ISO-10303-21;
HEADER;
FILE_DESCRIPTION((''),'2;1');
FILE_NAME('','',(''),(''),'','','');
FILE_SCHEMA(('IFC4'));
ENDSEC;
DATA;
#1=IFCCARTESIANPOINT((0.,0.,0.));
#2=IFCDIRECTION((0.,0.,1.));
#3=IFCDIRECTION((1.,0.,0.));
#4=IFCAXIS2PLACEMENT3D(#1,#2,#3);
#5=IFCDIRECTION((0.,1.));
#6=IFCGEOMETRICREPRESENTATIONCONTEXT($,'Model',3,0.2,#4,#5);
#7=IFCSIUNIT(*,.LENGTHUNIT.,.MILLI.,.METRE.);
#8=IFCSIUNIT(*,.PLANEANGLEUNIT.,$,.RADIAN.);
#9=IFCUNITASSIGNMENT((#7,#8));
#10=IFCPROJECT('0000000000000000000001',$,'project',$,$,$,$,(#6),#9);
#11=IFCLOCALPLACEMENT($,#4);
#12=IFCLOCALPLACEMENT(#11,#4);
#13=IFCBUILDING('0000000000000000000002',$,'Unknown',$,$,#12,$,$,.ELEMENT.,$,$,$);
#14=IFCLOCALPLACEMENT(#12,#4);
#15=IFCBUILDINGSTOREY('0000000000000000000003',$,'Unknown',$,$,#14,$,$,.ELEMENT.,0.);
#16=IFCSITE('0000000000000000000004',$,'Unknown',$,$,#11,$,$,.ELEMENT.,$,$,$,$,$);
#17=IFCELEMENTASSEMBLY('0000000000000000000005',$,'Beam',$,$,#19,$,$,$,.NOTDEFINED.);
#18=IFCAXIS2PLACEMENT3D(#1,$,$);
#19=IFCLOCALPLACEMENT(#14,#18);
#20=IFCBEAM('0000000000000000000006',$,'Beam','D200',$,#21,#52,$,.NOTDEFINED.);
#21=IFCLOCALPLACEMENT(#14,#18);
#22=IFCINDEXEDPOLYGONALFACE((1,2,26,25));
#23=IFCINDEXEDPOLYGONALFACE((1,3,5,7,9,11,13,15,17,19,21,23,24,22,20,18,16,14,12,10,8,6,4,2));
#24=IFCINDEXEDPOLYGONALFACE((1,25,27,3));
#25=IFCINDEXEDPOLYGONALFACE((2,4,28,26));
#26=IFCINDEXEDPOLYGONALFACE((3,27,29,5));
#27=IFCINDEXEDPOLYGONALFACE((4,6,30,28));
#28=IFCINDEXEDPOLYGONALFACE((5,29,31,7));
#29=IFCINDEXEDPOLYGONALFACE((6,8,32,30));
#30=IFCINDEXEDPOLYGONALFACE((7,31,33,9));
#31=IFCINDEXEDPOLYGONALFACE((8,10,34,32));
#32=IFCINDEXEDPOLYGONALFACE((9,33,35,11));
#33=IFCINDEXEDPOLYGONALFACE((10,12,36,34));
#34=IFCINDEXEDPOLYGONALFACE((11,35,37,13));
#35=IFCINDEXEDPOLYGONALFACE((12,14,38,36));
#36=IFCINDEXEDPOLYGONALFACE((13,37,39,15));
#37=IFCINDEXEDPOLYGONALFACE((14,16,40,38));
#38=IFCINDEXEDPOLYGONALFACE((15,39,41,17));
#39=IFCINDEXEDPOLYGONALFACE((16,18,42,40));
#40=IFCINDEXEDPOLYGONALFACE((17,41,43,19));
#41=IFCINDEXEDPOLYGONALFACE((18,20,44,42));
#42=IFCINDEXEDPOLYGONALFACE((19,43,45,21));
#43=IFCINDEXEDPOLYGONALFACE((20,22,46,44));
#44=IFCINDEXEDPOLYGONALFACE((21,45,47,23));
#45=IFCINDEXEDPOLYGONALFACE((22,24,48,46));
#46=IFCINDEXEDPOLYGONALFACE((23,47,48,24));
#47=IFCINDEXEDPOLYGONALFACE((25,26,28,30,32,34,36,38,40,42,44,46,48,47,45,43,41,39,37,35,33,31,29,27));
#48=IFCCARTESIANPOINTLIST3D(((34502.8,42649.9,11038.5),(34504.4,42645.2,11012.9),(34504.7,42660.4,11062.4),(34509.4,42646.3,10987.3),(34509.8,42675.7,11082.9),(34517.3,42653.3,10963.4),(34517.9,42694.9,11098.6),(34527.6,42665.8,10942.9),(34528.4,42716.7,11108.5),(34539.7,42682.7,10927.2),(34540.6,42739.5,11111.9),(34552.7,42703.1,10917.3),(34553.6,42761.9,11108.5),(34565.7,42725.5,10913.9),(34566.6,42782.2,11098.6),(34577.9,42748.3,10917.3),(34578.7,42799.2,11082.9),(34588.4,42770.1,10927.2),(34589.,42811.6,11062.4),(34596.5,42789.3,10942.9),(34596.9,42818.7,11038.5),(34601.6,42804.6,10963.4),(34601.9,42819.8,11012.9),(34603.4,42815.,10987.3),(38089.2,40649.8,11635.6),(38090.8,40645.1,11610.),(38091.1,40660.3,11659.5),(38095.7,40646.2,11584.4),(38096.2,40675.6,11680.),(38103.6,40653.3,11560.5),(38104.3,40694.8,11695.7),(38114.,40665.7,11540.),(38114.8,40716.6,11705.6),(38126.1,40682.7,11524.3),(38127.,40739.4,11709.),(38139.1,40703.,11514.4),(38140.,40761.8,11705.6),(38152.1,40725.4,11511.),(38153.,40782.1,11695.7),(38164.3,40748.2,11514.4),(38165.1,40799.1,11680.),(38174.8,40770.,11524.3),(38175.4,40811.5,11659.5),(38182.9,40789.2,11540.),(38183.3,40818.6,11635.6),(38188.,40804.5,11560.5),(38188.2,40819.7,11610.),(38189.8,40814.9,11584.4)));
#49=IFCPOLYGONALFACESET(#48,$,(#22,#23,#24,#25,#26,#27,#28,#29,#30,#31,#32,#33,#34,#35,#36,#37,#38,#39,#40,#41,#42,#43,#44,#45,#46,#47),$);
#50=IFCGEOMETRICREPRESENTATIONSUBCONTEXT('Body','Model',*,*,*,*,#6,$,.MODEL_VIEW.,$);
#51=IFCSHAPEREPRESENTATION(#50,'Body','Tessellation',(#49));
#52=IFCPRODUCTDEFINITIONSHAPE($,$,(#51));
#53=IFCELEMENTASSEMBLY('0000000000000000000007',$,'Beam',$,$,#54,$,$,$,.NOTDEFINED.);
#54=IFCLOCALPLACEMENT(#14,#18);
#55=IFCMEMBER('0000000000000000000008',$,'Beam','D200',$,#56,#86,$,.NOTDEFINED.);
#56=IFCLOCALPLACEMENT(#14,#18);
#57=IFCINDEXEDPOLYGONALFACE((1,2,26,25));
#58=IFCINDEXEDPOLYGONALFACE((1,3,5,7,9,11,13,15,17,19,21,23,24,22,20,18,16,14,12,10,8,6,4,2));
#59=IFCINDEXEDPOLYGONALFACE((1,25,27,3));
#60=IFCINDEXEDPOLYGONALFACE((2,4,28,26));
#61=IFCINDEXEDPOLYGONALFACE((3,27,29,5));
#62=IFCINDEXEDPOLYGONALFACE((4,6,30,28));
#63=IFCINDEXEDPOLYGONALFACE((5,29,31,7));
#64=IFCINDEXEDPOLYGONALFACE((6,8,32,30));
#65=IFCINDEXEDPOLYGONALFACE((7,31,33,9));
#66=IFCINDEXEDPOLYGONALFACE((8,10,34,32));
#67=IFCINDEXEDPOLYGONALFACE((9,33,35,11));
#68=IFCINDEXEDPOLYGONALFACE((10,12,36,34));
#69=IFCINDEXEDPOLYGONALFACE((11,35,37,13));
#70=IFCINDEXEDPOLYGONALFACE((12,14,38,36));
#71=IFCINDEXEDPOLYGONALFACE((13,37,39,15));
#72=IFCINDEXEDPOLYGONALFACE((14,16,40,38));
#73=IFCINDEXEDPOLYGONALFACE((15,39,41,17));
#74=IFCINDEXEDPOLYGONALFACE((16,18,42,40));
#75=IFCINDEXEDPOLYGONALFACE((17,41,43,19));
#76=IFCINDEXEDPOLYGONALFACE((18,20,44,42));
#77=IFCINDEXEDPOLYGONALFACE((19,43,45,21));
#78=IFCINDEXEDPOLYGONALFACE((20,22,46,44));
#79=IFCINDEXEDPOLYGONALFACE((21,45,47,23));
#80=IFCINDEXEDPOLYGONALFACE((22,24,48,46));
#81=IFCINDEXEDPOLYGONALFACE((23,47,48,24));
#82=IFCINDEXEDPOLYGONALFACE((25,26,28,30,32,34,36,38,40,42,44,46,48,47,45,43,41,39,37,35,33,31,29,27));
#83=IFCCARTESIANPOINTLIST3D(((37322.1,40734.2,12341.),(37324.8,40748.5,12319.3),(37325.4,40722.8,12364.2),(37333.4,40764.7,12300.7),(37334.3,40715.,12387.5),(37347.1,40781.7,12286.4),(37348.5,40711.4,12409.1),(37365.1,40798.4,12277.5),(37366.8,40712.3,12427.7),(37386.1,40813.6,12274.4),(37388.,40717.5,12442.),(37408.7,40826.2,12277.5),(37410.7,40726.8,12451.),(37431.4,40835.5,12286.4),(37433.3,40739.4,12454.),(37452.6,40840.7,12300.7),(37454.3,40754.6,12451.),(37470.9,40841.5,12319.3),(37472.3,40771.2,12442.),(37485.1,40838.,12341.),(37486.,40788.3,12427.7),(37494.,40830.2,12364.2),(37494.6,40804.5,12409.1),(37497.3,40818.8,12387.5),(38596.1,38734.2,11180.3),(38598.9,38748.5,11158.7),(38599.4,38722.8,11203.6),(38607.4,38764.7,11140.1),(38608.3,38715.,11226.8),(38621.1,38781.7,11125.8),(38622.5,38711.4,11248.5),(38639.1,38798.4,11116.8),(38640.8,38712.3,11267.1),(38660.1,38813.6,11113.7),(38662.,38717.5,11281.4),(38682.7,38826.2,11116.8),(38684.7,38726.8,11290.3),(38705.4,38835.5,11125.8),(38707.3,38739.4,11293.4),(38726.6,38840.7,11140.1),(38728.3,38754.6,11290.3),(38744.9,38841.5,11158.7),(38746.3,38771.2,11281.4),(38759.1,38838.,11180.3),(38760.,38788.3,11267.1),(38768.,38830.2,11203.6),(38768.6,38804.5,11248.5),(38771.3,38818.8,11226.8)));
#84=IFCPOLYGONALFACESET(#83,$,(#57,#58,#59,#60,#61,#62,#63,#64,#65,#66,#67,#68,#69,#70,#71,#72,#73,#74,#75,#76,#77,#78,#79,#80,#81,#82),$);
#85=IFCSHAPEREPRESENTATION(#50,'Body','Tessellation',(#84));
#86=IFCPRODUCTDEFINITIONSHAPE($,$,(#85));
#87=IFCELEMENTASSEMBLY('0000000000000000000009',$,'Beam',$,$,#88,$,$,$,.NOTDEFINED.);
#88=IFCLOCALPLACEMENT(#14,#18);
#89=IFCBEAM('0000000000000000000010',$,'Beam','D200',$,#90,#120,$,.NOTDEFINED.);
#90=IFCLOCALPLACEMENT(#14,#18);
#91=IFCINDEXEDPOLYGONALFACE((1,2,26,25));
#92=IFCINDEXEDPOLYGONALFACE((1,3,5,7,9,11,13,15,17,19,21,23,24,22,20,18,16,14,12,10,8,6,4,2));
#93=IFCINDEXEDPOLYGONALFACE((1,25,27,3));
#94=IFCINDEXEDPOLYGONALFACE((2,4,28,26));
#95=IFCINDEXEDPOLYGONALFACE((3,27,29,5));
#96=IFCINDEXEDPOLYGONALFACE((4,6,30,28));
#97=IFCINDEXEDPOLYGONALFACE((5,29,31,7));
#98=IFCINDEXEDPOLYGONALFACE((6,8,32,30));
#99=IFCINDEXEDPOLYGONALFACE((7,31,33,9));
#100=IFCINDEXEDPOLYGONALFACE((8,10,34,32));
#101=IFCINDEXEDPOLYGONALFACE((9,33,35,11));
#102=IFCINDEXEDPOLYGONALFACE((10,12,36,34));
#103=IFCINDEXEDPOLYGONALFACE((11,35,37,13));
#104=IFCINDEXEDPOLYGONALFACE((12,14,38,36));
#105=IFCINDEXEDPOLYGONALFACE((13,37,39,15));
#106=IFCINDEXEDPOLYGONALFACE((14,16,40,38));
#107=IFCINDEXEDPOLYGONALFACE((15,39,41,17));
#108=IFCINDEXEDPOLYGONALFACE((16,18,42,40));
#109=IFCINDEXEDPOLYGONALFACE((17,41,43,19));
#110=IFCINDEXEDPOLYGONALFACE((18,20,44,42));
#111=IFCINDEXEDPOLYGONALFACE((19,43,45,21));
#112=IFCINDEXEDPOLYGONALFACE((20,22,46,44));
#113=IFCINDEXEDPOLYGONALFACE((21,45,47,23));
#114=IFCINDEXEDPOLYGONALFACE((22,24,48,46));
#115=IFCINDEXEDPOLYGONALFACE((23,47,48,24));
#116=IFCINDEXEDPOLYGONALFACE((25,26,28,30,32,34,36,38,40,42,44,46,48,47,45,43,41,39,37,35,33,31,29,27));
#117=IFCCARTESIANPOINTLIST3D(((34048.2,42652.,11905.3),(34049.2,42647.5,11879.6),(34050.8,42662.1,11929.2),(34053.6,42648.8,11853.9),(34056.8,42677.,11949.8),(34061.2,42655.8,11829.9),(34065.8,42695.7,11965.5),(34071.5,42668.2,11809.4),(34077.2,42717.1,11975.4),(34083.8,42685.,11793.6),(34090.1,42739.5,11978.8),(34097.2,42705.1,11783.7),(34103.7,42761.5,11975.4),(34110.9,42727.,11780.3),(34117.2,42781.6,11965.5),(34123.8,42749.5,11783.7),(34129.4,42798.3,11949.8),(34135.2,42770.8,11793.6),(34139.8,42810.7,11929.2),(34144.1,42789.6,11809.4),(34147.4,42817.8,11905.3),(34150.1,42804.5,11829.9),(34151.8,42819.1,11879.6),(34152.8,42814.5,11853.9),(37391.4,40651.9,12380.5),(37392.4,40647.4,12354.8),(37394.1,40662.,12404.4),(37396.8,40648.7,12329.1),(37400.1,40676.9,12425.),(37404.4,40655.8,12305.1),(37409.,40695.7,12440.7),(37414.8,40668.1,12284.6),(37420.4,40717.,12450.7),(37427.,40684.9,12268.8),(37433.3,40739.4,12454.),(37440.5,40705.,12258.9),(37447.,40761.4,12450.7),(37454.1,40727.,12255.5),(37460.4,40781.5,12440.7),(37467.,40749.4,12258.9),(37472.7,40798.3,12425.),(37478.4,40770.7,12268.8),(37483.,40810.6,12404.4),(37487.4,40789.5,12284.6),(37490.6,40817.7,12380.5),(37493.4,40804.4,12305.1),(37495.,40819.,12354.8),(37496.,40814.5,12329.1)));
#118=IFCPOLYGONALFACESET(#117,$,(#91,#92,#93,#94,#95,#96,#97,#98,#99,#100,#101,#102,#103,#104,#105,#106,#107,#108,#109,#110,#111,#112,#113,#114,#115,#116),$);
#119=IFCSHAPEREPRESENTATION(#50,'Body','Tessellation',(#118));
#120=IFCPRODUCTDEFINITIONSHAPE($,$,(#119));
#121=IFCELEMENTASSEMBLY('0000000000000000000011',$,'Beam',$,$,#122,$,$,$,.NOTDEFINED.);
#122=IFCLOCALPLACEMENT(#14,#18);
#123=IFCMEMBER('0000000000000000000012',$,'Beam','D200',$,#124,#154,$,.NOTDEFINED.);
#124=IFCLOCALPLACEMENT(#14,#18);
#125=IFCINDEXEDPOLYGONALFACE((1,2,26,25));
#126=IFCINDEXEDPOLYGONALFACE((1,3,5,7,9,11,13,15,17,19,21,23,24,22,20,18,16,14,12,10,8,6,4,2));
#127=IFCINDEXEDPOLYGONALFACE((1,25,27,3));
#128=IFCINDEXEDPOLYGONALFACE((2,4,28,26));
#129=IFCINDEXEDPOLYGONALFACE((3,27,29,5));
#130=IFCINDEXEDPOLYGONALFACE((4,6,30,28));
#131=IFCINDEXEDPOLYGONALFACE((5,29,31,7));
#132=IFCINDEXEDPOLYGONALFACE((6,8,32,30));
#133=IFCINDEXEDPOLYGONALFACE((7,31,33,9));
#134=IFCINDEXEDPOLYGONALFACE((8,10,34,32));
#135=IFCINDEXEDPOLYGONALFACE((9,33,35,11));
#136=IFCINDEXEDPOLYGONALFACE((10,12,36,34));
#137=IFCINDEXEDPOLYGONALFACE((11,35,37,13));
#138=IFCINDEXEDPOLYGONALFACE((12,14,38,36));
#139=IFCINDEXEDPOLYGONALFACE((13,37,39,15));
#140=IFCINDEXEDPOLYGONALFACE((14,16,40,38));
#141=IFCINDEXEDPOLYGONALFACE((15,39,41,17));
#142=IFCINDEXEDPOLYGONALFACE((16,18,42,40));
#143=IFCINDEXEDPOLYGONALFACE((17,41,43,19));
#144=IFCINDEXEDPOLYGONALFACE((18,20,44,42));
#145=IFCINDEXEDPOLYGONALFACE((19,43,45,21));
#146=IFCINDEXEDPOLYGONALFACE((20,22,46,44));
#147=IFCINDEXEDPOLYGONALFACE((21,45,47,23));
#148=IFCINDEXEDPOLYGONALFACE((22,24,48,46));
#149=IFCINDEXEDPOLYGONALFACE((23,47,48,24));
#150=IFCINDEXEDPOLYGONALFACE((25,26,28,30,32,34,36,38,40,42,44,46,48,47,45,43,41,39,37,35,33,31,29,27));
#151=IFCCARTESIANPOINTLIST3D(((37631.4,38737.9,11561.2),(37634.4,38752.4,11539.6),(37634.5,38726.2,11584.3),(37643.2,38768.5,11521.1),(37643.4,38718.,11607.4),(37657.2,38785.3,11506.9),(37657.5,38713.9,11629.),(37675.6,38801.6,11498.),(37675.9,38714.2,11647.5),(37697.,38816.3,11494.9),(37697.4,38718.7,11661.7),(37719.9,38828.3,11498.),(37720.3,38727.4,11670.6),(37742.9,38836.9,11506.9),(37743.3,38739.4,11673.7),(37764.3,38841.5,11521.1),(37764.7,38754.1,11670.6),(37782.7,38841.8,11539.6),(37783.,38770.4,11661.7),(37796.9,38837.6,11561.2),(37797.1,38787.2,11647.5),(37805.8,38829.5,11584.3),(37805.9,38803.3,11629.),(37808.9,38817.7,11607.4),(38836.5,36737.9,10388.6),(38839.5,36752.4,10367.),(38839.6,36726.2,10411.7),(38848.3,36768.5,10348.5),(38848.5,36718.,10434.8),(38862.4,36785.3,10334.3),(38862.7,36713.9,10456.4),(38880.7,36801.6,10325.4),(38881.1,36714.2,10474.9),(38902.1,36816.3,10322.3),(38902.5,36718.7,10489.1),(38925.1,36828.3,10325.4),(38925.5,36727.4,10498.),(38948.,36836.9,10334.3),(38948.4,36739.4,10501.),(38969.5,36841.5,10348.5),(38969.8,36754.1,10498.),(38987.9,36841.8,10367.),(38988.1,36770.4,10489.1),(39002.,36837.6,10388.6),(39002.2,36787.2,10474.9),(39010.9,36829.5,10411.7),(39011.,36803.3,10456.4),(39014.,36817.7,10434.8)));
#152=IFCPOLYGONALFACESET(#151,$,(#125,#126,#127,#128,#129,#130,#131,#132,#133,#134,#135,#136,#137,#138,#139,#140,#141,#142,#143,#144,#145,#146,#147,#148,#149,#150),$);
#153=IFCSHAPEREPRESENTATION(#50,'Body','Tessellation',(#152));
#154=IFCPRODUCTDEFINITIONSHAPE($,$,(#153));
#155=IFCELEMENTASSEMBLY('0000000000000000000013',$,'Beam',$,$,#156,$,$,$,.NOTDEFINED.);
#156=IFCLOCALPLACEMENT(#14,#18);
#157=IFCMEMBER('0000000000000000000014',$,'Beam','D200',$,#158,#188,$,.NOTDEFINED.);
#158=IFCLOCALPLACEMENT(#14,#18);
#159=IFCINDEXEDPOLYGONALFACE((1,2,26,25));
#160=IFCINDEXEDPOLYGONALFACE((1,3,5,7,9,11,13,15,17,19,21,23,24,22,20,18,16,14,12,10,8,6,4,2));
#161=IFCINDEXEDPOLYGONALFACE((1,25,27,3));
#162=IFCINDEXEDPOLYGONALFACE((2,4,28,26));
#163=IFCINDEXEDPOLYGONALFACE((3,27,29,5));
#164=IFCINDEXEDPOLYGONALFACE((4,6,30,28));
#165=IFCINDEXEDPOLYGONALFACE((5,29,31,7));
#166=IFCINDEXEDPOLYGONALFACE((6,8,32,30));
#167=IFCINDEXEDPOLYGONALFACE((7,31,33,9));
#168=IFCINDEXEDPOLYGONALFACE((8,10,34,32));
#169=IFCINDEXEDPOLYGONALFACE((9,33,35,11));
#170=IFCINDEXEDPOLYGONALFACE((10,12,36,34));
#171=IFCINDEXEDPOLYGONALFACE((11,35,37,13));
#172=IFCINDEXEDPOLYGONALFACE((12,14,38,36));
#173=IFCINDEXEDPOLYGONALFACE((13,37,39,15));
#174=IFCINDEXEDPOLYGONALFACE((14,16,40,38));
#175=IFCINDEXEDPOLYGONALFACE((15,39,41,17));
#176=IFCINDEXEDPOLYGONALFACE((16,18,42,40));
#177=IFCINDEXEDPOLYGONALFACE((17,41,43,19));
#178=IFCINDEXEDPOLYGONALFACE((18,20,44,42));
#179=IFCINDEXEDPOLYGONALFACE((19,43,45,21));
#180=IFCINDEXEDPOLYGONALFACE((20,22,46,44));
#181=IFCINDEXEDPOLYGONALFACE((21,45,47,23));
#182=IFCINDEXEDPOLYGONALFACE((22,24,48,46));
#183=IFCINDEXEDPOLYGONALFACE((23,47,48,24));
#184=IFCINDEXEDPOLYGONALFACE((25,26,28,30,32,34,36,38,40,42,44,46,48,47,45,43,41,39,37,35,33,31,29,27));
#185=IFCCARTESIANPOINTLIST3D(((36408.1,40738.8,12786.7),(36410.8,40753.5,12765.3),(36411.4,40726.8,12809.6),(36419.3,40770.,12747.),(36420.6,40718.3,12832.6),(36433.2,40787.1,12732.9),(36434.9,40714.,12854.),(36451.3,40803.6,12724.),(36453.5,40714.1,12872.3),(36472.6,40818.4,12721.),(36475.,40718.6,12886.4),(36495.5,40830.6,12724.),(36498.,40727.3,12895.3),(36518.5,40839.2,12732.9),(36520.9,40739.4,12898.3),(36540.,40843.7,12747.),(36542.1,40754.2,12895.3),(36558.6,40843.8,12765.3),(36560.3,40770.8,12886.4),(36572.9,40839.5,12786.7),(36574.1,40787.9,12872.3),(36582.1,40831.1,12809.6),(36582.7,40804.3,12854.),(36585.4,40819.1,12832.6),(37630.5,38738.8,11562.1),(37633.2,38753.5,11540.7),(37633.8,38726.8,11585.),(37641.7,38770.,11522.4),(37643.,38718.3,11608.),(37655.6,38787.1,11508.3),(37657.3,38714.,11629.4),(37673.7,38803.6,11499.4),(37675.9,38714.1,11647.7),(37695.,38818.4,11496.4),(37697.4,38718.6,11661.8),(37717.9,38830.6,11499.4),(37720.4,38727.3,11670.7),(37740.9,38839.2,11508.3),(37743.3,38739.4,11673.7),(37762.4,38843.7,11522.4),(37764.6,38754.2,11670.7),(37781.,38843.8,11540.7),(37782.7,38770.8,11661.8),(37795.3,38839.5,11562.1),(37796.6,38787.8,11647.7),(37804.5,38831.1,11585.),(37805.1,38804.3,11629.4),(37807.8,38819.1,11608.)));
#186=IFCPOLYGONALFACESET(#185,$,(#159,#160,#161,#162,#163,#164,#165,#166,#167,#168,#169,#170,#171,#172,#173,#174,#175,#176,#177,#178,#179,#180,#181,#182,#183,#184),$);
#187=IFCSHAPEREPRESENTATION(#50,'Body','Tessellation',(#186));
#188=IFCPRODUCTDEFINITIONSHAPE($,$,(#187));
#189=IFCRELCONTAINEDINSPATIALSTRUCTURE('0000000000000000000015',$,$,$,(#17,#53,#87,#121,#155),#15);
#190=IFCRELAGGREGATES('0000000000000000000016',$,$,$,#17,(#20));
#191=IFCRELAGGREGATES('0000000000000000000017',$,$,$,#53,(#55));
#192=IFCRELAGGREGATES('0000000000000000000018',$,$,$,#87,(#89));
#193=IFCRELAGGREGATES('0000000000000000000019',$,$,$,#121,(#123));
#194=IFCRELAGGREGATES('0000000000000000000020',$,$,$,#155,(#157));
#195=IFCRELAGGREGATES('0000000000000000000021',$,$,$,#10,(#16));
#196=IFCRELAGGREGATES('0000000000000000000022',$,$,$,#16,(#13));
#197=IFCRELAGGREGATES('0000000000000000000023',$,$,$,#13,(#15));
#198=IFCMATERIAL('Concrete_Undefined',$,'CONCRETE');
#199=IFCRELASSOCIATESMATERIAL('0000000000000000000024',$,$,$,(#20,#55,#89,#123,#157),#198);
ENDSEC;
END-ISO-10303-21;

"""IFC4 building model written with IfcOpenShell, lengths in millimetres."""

from ifc_helpers import new_model, si_unit, direction, frame, origin_with_axes, place, context, subcontext, project, spatial, line, indexed_curve, outline, extrude, material, element, aggregate, save


model = new_model("IFC4")

# Units and contexts
model_context = context("Model", 3, precision=0.2, world=origin_with_axes(), true_north=direction((0.0, 1.0)))
body_context = subcontext(model_context, "Body", "Model", "MODEL_VIEW")
ifc_project = project(units=[si_unit("LENGTHUNIT", "METRE", prefix="MILLI"), si_unit("PLANEANGLEUNIT", "RADIAN")], contexts=[model_context])

# Site, building, storey
site_placement = place(None, origin_with_axes())
site = spatial("IfcSite", under=ifc_project, at=site_placement, Name="Unknown", CompositionType="ELEMENT")
building_placement = place(site_placement, origin_with_axes())
building = spatial("IfcBuilding", under=site, at=building_placement, Name="Unknown", CompositionType="ELEMENT")
storey_placement = place(building_placement, origin_with_axes())
storey = spatial("IfcBuildingStorey", under=building, at=storey_placement, Name="Unknown", CompositionType="ELEMENT", Elevation=0.0)

# Element assembly, beam
ifc_material = material(Name="Concrete_Undefined", Category="CONCRETE")
assembly_1_placement = place(storey_placement, frame((34553.1, 42732.5, 11012.9), z_axis=(-0.487068, -0.873364, 0.0), x_axis=(0.864275, -0.482, 0.143892)))
assembly_1 = element("IfcElementAssembly", 1, at=assembly_1_placement, inside=storey, Name="Beam", PredefinedType="NOTDEFINED")
beam_1_placement = place(assembly_1_placement, origin_with_axes())
beam_1 = element("IfcBeam", 2, at=beam_1_placement, material=ifc_material, Name="Beam", Description="D200", PredefinedType="NOTDEFINED", context=body_context, shape_type="SolidModel", body=[
    extrude(outline(indexed_curve([(100.0, 0.0), (96.6, 25.9), (86.6, 50.0), (70.7, 70.7), (50.0, 86.6), (25.9, 96.6), (0.0, 100.0), (-25.9, 96.6), (-50.0, 86.6), (-70.7, 70.7), (-86.6, 50.0), (-96.6, 25.9), (-100.0, 0.0), (-96.6, -25.9), (-86.6, -50.0), (-70.7, -70.7), (-50.0, -86.6), (-25.9, -96.6), (0.0, -100.0), (25.9, -96.6), (50.0, -86.6), (70.7, -70.7), (86.6, -50.0), (96.6, -25.9)], segments=[line(1, 2, 3, 4, 5, 6, 7, 8, 9, 10, 11, 12, 13, 14, 15, 16, 17, 18, 19, 20, 21, 22, 23, 24, 1)])), frame((0.0, 0.0, 0.0), z_axis=(-1.0, 0.0, 0.0), x_axis=(0.0, 0.0, 1.0)), (0.0, 0.0, -1.0), 4149.6),
])
aggregate(assembly_1, [beam_1])

# Element assembly, member
assembly_2_placement = place(storey_placement, frame((37409.7, 40776.5, 12364.2), z_axis=(-0.843418, -0.537259, 0.0), x_axis=(0.482557, -0.757544, -0.43962)))
assembly_2 = element("IfcElementAssembly", 3, at=assembly_2_placement, inside=storey, Name="Beam", PredefinedType="NOTDEFINED")
member_1_placement = place(assembly_2_placement, origin_with_axes())
member_1 = element("IfcMember", 4, at=member_1_placement, material=ifc_material, Name="Beam", Description="D200", PredefinedType="NOTDEFINED", context=body_context, shape_type="SolidModel", body=[
    extrude(outline(indexed_curve([(100.0, 0.0), (96.6, 25.9), (86.6, 50.0), (70.7, 70.7), (50.0, 86.6), (25.9, 96.6), (0.0, 100.0), (-25.9, 96.6), (-50.0, 86.6), (-70.7, 70.7), (-86.6, 50.0), (-96.6, 25.9), (-100.0, 0.0), (-96.6, -25.9), (-86.6, -50.0), (-70.7, -70.7), (-50.0, -86.6), (-25.9, -96.6), (0.0, -100.0), (25.9, -96.6), (50.0, -86.6), (70.7, -70.7), (86.6, -50.0), (96.6, -25.9)], segments=[line(1, 2, 3, 4, 5, 6, 7, 8, 9, 10, 11, 12, 13, 14, 15, 16, 17, 18, 19, 20, 21, 22, 23, 24, 1)])), frame((0.0, 0.0, 0.0), z_axis=(-1.0, 0.0, 0.0), x_axis=(0.0, 0.0, 1.0)), (0.0, 0.0, -1.0), 2640.1),
])
aggregate(assembly_2, [member_1])

# Element assembly, beam
assembly_3_placement = place(storey_placement, frame((34100.5, 42733.3, 11879.6), z_axis=(-0.513391, -0.858155, 0.0), x_axis=(0.851841, -0.509614, 0.12108)))
assembly_3 = element("IfcElementAssembly", 5, at=assembly_3_placement, inside=storey, Name="Beam", PredefinedType="NOTDEFINED")
beam_2_placement = place(assembly_3_placement, origin_with_axes())
beam_2 = element("IfcBeam", 6, at=beam_2_placement, material=ifc_material, Name="Beam", Description="D200", PredefinedType="NOTDEFINED", context=body_context, shape_type="SolidModel", body=[
    extrude(outline(indexed_curve([(100.0, 0.0), (96.6, 25.9), (86.6, 50.0), (70.7, 70.7), (50.0, 86.6), (25.9, 96.6), (0.0, 100.0), (-25.9, 96.6), (-50.0, 86.6), (-70.7, 70.7), (-86.6, 50.0), (-96.6, 25.9), (-100.0, 0.0), (-96.6, -25.9), (-86.6, -50.0), (-70.7, -70.7), (-50.0, -86.6), (-25.9, -96.6), (0.0, -100.0), (25.9, -96.6), (50.0, -86.6), (70.7, -70.7), (86.6, -50.0), (96.6, -25.9)], segments=[line(1, 2, 3, 4, 5, 6, 7, 8, 9, 10, 11, 12, 13, 14, 15, 16, 17, 18, 19, 20, 21, 22, 23, 24, 1)])), frame((0.0, 0.0, 0.0), z_axis=(-1.0, 0.0, 0.0), x_axis=(0.0, 0.0, 1.0)), (0.0, 0.0, -1.0), 3924.7),
])
aggregate(assembly_3, [beam_2])

# Element assemblies, members
assembly_4_placement = place(storey_placement, frame((37720.1, 38777.8, 11584.3), z_axis=(-0.856522, -0.51611, 0.0), x_axis=(0.461218, -0.765426, -0.448777)))
assembly_4 = element("IfcElementAssembly", 7, at=assembly_4_placement, inside=storey, Name="Beam", PredefinedType="NOTDEFINED")
member_2_placement = place(assembly_4_placement, origin_with_axes())
member_2 = element("IfcMember", 8, at=member_2_placement, material=ifc_material, Name="Beam", Description="D200", PredefinedType="NOTDEFINED", context=body_context, shape_type="SolidModel", body=[
    extrude(outline(indexed_curve([(100.0, 0.0), (96.6, 25.9), (86.6, 50.0), (70.7, 70.7), (50.0, 86.6), (25.9, 96.6), (0.0, 100.0), (-25.9, 96.6), (-50.0, 86.6), (-70.7, 70.7), (-86.6, 50.0), (-96.6, 25.9), (-100.0, 0.0), (-96.6, -25.9), (-86.6, -50.0), (-70.7, -70.7), (-50.0, -86.6), (-25.9, -96.6), (0.0, -100.0), (25.9, -96.6), (50.0, -86.6), (70.7, -70.7), (86.6, -50.0), (96.6, -25.9)], segments=[line(1, 2, 3, 4, 5, 6, 7, 8, 9, 10, 11, 12, 13, 14, 15, 16, 17, 18, 19, 20, 21, 22, 23, 24, 1)])), frame((0.0, 0.0, 0.0), z_axis=(-1.0, 0.0, 0.0), x_axis=(0.0, 0.0, 1.0)), (0.0, 0.0, -1.0), 2612.9),
])
aggregate(assembly_4, [member_2])
assembly_5_placement = place(storey_placement, frame((36496.7, 40778.9, 12809.6), z_axis=(-0.853246, -0.521508, 0.0), x_axis=(0.462227, -0.756256, -0.463057)))
assembly_5 = element("IfcElementAssembly", 9, at=assembly_5_placement, inside=storey, Name="Beam", PredefinedType="NOTDEFINED")
member_3_placement = place(assembly_5_placement, origin_with_axes())
member_3 = element("IfcMember", 10, at=member_3_placement, material=ifc_material, Name="Beam", Description="D200", PredefinedType="NOTDEFINED", context=body_context, shape_type="SolidModel", body=[
    extrude(outline(indexed_curve([(100.0, 0.0), (96.6, 25.9), (86.6, 50.0), (70.7, 70.7), (50.0, 86.6), (25.9, 96.6), (0.0, 100.0), (-25.9, 96.6), (-50.0, 86.6), (-70.7, 70.7), (-86.6, 50.0), (-96.6, 25.9), (-100.0, 0.0), (-96.6, -25.9), (-86.6, -50.0), (-70.7, -70.7), (-50.0, -86.6), (-25.9, -96.6), (0.0, -100.0), (25.9, -96.6), (50.0, -86.6), (70.7, -70.7), (86.6, -50.0), (96.6, -25.9)], segments=[line(1, 2, 3, 4, 5, 6, 7, 8, 9, 10, 11, 12, 13, 14, 15, 16, 17, 18, 19, 20, 21, 22, 23, 24, 1)])), frame((0.0, 0.0, 0.0), z_axis=(-1.0, 0.0, 0.0), x_axis=(0.0, 0.0, 1.0)), (0.0, 0.0, -1.0), 2644.6),
])
aggregate(assembly_5, [member_3])

save(model, "model.ifc")
